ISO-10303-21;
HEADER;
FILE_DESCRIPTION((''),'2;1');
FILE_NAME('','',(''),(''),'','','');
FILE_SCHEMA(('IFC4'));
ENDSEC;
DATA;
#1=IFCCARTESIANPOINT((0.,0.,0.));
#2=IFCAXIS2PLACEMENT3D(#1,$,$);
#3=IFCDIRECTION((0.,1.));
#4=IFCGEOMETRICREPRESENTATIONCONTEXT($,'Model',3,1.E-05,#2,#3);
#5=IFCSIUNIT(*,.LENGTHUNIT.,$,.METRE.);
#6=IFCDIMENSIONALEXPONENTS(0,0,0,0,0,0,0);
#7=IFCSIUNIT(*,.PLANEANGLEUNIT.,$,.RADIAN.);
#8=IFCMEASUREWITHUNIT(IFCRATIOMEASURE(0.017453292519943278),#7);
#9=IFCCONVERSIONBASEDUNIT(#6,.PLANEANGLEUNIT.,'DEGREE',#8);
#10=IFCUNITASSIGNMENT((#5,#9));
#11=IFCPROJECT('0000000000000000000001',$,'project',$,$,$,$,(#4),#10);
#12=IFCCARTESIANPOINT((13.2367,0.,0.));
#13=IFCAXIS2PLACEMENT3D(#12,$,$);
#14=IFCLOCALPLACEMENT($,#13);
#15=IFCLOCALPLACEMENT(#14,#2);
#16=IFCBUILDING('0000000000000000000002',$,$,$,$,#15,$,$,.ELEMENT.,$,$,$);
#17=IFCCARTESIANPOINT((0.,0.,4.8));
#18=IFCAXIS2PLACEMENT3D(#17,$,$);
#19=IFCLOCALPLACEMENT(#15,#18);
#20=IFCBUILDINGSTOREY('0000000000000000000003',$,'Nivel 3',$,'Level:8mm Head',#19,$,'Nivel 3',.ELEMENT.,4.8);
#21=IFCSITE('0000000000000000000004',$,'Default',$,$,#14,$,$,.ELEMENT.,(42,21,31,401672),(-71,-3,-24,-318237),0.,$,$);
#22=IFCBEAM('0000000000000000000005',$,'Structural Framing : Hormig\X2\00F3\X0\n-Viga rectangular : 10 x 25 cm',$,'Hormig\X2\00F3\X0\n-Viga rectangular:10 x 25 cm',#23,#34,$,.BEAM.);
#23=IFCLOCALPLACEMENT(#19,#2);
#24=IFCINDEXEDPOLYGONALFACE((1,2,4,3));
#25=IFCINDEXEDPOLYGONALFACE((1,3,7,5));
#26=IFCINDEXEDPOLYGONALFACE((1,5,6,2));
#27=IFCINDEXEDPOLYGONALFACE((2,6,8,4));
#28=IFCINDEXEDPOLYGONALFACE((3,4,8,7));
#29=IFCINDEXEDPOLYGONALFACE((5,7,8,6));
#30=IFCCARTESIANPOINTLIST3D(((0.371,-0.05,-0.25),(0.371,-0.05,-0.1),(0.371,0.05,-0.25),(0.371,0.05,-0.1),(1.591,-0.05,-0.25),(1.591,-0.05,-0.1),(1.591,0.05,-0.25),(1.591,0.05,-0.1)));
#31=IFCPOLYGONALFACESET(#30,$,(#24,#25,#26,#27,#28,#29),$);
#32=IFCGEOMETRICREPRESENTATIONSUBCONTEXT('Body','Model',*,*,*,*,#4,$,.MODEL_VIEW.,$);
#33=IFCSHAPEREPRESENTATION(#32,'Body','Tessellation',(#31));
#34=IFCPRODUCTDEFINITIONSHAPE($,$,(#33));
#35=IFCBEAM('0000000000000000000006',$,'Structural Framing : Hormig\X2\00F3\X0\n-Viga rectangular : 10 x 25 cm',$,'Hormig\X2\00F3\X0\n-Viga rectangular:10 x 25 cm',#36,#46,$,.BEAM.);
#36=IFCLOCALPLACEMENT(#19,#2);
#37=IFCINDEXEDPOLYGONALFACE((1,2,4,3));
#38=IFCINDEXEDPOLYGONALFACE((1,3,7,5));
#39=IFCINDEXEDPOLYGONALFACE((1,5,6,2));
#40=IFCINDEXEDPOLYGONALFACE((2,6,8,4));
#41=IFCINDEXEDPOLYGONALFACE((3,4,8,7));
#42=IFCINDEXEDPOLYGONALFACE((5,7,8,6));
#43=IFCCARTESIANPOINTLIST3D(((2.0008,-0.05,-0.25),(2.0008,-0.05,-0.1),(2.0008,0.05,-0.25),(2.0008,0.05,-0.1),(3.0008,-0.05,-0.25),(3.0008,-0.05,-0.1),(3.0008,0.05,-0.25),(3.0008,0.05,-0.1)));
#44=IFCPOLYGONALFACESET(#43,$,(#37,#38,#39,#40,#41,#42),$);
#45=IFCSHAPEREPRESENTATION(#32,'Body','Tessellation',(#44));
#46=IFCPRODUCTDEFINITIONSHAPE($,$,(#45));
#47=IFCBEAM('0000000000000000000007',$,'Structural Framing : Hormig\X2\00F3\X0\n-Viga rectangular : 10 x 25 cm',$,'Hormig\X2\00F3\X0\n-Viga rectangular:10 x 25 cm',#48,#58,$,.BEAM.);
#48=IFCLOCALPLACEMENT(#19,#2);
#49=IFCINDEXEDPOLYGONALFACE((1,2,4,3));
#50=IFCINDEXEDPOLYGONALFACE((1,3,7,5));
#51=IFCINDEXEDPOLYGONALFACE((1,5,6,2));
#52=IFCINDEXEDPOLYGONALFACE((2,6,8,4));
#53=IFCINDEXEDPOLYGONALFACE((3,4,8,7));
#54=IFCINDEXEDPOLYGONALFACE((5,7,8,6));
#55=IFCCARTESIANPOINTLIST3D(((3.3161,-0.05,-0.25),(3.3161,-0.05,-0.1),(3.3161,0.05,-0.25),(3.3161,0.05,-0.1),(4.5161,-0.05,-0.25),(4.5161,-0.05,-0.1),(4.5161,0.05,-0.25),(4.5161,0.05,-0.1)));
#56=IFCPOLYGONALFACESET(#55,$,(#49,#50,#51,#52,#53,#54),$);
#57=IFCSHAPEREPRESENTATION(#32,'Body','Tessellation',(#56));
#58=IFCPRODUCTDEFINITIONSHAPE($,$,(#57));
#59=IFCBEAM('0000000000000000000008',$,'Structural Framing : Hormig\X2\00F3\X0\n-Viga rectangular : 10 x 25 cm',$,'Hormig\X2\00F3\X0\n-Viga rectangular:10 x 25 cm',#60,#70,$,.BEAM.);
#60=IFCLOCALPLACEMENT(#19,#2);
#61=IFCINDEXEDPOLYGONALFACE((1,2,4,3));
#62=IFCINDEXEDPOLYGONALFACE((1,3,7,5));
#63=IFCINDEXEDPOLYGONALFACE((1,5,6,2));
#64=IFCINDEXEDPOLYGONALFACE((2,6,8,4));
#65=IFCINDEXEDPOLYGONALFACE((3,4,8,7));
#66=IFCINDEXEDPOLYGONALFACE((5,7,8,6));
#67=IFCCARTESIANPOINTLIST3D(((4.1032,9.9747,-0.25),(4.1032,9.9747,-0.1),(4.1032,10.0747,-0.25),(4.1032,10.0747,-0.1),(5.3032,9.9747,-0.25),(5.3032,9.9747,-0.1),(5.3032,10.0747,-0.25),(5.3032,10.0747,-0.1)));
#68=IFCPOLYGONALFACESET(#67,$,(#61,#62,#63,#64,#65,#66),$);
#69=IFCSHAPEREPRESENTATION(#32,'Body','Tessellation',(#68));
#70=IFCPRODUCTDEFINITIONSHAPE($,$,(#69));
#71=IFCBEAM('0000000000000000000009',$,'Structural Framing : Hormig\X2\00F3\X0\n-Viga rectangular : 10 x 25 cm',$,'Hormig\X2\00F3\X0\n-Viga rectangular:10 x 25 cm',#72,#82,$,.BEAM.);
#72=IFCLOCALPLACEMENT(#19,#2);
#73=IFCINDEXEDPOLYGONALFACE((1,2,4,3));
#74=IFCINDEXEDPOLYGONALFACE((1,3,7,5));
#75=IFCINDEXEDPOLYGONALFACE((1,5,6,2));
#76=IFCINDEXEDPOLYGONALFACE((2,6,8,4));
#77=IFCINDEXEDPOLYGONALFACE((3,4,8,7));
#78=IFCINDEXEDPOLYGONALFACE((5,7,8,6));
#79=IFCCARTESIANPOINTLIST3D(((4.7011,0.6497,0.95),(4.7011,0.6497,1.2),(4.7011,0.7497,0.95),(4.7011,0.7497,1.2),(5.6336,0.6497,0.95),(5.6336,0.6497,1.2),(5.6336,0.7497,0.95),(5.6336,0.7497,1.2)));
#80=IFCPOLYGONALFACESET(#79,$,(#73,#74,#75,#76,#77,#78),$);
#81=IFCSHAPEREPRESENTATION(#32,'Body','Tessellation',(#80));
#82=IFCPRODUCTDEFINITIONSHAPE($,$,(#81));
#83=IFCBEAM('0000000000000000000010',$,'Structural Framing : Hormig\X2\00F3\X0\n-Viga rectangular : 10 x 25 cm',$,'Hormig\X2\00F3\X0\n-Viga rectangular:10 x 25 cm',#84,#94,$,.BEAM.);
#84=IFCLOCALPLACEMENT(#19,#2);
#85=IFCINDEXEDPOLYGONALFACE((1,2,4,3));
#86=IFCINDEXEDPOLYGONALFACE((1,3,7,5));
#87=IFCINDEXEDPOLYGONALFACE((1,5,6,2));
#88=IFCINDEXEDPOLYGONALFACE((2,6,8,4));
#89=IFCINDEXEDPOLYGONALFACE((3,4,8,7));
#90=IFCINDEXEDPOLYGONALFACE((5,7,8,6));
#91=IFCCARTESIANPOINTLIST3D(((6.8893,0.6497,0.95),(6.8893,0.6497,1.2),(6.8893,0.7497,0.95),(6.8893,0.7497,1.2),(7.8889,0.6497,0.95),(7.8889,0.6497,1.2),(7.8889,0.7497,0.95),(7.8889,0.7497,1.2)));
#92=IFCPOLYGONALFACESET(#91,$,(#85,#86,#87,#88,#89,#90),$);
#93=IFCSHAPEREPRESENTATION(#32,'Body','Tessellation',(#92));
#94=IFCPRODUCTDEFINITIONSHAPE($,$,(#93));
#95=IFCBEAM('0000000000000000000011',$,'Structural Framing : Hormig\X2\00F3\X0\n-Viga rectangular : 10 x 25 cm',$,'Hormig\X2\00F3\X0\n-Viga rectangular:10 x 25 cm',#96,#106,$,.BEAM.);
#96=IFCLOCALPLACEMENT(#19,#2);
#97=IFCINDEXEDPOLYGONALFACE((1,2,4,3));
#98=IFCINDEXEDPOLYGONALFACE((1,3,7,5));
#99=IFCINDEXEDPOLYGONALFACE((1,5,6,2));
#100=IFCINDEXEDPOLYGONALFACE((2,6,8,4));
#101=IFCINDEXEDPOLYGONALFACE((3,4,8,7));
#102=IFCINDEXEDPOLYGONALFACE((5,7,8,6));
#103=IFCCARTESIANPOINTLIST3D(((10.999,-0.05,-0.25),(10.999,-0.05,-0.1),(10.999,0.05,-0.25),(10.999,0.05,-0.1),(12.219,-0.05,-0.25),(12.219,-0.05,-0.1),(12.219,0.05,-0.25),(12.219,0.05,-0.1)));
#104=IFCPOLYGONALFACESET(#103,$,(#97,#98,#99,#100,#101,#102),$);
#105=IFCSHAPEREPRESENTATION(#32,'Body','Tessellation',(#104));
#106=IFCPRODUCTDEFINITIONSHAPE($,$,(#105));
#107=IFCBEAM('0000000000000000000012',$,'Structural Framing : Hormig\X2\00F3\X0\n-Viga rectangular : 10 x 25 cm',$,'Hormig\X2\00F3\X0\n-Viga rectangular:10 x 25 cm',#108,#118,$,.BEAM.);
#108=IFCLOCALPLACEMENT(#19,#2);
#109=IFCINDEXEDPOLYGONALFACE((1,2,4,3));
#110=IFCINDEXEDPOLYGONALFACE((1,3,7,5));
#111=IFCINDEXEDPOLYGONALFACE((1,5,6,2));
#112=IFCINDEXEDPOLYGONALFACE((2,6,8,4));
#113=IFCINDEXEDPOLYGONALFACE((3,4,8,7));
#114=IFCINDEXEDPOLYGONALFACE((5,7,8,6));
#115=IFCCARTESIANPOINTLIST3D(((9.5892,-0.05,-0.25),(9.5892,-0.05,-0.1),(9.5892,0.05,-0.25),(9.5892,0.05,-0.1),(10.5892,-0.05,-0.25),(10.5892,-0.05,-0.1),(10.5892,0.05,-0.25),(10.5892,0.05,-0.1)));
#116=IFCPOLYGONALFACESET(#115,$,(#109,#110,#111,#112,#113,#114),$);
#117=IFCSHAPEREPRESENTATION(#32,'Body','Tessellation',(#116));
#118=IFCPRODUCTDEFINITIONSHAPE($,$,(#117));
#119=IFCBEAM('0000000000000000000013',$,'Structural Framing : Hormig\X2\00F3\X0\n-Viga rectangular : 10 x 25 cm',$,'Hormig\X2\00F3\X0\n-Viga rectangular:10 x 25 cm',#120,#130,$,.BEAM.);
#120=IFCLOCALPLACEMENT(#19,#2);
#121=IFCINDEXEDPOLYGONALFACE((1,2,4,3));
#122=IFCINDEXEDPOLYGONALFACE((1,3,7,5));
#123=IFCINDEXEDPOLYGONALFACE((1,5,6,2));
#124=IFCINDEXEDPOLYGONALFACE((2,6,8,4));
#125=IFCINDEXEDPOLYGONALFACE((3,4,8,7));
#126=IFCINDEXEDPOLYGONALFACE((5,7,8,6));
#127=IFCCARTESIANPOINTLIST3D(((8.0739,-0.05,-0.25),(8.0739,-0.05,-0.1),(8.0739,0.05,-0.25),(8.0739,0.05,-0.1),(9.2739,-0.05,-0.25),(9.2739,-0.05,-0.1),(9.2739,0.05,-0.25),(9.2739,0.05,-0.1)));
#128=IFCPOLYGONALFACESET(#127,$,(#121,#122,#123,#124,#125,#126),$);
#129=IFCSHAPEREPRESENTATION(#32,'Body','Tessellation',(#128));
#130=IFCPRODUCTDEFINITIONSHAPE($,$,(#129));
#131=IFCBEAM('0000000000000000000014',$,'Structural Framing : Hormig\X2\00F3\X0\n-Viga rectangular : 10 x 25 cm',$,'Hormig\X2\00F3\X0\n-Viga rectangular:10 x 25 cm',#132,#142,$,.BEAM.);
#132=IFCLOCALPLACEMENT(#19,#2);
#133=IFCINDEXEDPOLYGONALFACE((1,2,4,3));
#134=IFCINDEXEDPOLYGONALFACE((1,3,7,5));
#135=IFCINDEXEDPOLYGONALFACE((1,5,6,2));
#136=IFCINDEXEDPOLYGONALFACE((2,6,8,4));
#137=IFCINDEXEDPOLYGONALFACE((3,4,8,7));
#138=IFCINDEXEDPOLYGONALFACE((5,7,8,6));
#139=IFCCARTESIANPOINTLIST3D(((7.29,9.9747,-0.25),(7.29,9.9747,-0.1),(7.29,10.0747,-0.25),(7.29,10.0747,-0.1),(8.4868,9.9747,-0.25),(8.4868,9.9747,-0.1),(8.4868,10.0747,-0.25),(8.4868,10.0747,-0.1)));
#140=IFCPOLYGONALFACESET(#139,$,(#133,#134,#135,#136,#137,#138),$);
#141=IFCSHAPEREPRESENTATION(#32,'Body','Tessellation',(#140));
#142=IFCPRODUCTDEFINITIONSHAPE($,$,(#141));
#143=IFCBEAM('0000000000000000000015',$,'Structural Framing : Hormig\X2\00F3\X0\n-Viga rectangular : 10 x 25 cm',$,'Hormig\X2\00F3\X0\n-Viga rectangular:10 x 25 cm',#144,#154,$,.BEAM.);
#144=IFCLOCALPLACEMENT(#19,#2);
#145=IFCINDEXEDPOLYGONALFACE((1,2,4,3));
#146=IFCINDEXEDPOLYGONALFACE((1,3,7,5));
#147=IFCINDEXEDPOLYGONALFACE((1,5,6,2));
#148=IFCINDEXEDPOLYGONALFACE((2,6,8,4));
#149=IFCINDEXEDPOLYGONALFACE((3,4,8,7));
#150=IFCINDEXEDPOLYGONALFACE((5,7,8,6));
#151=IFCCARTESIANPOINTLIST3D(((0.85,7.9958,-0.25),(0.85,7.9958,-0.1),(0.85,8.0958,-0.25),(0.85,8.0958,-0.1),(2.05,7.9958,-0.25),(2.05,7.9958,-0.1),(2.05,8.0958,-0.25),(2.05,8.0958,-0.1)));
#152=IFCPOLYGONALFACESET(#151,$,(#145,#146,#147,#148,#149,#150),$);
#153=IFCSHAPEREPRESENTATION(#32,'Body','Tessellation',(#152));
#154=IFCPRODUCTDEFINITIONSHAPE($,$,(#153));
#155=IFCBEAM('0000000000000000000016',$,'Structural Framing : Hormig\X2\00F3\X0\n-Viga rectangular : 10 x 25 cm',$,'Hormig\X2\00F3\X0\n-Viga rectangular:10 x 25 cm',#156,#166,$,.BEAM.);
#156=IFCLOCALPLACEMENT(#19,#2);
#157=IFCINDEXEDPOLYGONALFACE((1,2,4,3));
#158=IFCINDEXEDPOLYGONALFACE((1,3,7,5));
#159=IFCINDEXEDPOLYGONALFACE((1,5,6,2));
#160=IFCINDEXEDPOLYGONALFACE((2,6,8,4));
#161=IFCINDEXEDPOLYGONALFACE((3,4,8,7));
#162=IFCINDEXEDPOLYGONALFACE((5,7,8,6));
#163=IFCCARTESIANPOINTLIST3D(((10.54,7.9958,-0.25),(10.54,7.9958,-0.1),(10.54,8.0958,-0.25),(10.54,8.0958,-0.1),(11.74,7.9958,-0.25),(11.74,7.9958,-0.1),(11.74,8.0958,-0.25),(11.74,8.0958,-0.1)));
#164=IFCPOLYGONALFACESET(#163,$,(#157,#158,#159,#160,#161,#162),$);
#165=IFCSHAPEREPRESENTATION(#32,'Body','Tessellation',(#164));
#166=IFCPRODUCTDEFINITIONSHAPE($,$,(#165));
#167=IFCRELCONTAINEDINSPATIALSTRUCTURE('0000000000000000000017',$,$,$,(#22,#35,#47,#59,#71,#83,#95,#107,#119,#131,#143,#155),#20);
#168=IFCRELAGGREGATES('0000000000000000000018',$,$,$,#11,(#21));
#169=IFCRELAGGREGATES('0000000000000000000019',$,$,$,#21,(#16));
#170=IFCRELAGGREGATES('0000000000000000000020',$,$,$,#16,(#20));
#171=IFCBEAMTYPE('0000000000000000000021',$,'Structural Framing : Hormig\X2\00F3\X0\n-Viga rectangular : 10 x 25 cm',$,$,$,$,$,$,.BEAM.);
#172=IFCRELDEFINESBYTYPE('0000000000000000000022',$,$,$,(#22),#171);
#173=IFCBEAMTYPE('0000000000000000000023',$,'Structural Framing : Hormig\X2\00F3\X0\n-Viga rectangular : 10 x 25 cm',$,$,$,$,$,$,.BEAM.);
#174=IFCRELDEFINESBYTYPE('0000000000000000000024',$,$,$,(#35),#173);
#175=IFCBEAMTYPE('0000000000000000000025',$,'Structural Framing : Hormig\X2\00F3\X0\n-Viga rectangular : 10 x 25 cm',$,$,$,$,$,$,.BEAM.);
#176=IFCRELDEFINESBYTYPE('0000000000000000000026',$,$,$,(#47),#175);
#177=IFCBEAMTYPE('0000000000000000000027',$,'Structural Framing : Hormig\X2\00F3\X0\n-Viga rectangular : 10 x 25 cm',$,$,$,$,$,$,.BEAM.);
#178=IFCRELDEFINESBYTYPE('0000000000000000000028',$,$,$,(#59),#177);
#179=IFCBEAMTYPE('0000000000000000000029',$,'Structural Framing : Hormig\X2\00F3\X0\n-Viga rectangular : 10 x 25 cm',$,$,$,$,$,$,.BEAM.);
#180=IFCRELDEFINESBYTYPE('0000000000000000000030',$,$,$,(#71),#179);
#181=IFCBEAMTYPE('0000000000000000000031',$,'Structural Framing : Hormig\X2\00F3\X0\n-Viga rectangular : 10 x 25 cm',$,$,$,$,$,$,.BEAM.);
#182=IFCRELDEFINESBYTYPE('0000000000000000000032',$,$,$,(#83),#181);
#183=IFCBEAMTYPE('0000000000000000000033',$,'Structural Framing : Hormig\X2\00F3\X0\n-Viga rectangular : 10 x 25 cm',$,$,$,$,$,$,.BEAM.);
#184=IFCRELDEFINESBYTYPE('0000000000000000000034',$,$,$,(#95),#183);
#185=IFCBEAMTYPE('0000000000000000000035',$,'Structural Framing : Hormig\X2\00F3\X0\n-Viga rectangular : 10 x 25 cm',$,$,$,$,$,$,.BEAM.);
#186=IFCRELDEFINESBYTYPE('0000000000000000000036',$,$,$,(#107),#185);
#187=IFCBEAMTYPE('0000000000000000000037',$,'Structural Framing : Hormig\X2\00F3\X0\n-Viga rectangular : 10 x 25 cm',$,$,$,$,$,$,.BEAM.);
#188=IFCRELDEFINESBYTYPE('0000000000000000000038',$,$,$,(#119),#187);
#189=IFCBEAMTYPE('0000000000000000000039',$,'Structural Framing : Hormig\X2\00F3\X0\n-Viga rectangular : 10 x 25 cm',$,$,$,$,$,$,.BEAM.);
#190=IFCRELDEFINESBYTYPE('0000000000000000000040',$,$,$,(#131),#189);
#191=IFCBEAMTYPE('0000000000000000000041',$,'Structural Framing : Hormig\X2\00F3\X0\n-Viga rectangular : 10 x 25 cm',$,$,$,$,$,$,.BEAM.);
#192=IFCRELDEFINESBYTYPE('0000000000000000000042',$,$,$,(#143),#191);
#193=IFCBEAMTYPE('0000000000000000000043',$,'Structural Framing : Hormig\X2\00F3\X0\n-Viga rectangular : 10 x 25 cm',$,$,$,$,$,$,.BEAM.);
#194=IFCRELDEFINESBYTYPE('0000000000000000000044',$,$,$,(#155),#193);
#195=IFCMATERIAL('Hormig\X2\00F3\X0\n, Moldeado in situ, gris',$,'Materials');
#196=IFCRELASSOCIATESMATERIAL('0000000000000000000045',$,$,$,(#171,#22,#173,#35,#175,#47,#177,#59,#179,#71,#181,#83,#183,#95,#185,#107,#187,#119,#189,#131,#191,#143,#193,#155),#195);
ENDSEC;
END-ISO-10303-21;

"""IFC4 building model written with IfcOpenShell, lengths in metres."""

from ifc_helpers import new_model, entity, si_unit, converted_unit, direction, frame, origin, place, context, subcontext, project, spatial, indexed_curve, outline, extrude, source, transform, mapped, material, type_object, type_shapes, element, save


model = new_model("IFC4")

# Units and contexts
model_context = context("Model", 3, precision=1e-05, world=origin(), true_north=direction((0.0, 1.0)))
body_context = subcontext(model_context, "Body", "Model", "MODEL_VIEW")
ifc_project = project(units=[si_unit("LENGTHUNIT", "METRE"), converted_unit("PLANEANGLEUNIT", "DEGREE", entity("IfcRatioMeasure", 0.017453292519943278), si_unit("PLANEANGLEUNIT", "RADIAN"), dimensions=[0, 0, 0, 0, 0, 0, 0])], contexts=[model_context])

# Site, building, storey
site_placement = place(None, frame((13.2367, 0.0, 0.0)))
site = spatial("IfcSite", under=ifc_project, at=site_placement, Name="Default", CompositionType="ELEMENT", RefLatitude=(42, 21, 31, 401672), RefLongitude=(-71, -3, -24, -318237), RefElevation=0.0)
building_placement = place(site_placement, origin())
building = spatial("IfcBuilding", under=site, at=building_placement, CompositionType="ELEMENT")
storey_placement = place(building_placement, frame((0.0, 0.0, 4.8)))
storey = spatial("IfcBuildingStorey", under=building, at=storey_placement, Name="Nivel 3", ObjectType="Level:8mm Head", LongName="Nivel 3", CompositionType="ELEMENT", Elevation=4.8)

# Beams
ifc_material_1 = material(Name="Hormigón, Moldeado in situ, gris", Category="Materials")
beam_type_1 = type_object("IfcBeamType", Name="Structural Framing : Hormigón-Viga rectangular : 10 x 25 cm", PredefinedType="BEAM", material=ifc_material_1)
shared_shape_1 = source(origin(), body_context, "Body", "SweptSolid", [
    extrude(outline(indexed_curve([(-0.075, -0.05), (0.075, -0.05), (0.075, 0.05), (-0.075, 0.05), (-0.075, -0.05)], self_intersect=False)), frame((0.371, 0.0, 4.625), z_axis=(1.0, 0.0, 0.0), x_axis=(0.0, 0.0, -1.0)), (0.0, 0.0, 1.0), 1.22),
])
type_shapes(beam_type_1, [shared_shape_1])
beam_1_placement = place(storey_placement, frame((0.0, 0.0, -4.8)))
element("IfcBeam", 1, at=beam_1_placement, inside=storey, type_object=beam_type_1, material=ifc_material_1, Name="Structural Framing : Hormigón-Viga rectangular : 10 x 25 cm", ObjectType="Hormigón-Viga rectangular:10 x 25 cm", PredefinedType="BEAM", context=body_context, shape_type="MappedRepresentation", body=[
    mapped(shared_shape_1, transform((0.0, 0.0, 0.0), scale=1.0)),
])
beam_type_2 = type_object("IfcBeamType", Name="Structural Framing : Hormigón-Viga rectangular : 10 x 25 cm", PredefinedType="BEAM", material=ifc_material_1)
shared_shape_2 = source(origin(), body_context, "Body", "SweptSolid", [
    extrude(outline(indexed_curve([(-0.075, -0.05), (0.075, -0.05), (0.075, 0.05), (-0.075, 0.05), (-0.075, -0.05)], self_intersect=False)), frame((2.0008, 0.0, 4.625), z_axis=(1.0, 0.0, 0.0), x_axis=(0.0, 0.0, -1.0)), (0.0, 0.0, 1.0), 1.0),
])
type_shapes(beam_type_2, [shared_shape_2])
beam_2_placement = place(storey_placement, frame((0.0, 0.0, -4.8)))
element("IfcBeam", 2, at=beam_2_placement, inside=storey, type_object=beam_type_2, material=ifc_material_1, Name="Structural Framing : Hormigón-Viga rectangular : 10 x 25 cm", ObjectType="Hormigón-Viga rectangular:10 x 25 cm", PredefinedType="BEAM", context=body_context, shape_type="MappedRepresentation", body=[
    mapped(shared_shape_2, transform((0.0, 0.0, 0.0), scale=1.0)),
])
beam_type_3 = type_object("IfcBeamType", Name="Structural Framing : Hormigón-Viga rectangular : 10 x 25 cm", PredefinedType="BEAM", material=ifc_material_1)
shared_shape_3 = source(origin(), body_context, "Body", "SweptSolid", [
    extrude(outline(indexed_curve([(-0.075, -0.05), (0.075, -0.05), (0.075, 0.05), (-0.075, 0.05), (-0.075, -0.05)], self_intersect=False)), frame((3.3161, 0.0, 4.625), z_axis=(1.0, 0.0, 0.0), x_axis=(0.0, 0.0, -1.0)), (0.0, 0.0, 1.0), 1.2),
])
type_shapes(beam_type_3, [shared_shape_3])
beam_3_placement = place(storey_placement, frame((0.0, 0.0, -4.8)))
element("IfcBeam", 3, at=beam_3_placement, inside=storey, type_object=beam_type_3, material=ifc_material_1, Name="Structural Framing : Hormigón-Viga rectangular : 10 x 25 cm", ObjectType="Hormigón-Viga rectangular:10 x 25 cm", PredefinedType="BEAM", context=body_context, shape_type="MappedRepresentation", body=[
    mapped(shared_shape_3, transform((0.0, 0.0, 0.0), scale=1.0)),
])
beam_type_4 = type_object("IfcBeamType", Name="Structural Framing : Hormigón-Viga rectangular : 10 x 25 cm", PredefinedType="BEAM", material=ifc_material_1)
shared_shape_4 = source(origin(), body_context, "Body", "SweptSolid", [
    extrude(outline(indexed_curve([(-0.075, -0.05), (0.075, -0.05), (0.075, 0.05), (-0.075, 0.05), (-0.075, -0.05)], self_intersect=False)), frame((5.3032, 10.0247, 4.625), z_axis=(-1.0, 0.0, 0.0), x_axis=(0.0, 0.0, -1.0)), (0.0, 0.0, 1.0), 1.2),
])
type_shapes(beam_type_4, [shared_shape_4])
beam_4_placement = place(storey_placement, frame((0.0, 0.0, -4.8)))
element("IfcBeam", 4, at=beam_4_placement, inside=storey, type_object=beam_type_4, material=ifc_material_1, Name="Structural Framing : Hormigón-Viga rectangular : 10 x 25 cm", ObjectType="Hormigón-Viga rectangular:10 x 25 cm", PredefinedType="BEAM", context=body_context, shape_type="MappedRepresentation", body=[
    mapped(shared_shape_4, transform((0.0, 0.0, 0.0), scale=1.0)),
])
beam_type_5 = type_object("IfcBeamType", Name="Structural Framing : Hormigón-Viga rectangular : 10 x 25 cm", PredefinedType="BEAM", material=ifc_material_1)
shared_shape_5 = source(origin(), body_context, "Body", "SweptSolid", [
    extrude(outline(indexed_curve([(-0.125, -0.05), (0.125, -0.05), (0.125, 0.05), (-0.125, 0.05), (-0.125, -0.05)], self_intersect=False)), frame((5.6336, 0.6997, 5.875), z_axis=(-1.0, 0.0, 0.0), x_axis=(0.0, 0.0, -1.0)), (0.0, 0.0, 1.0), 0.9325),
])
type_shapes(beam_type_5, [shared_shape_5])
beam_5_placement = place(storey_placement, frame((0.0, 0.0, -4.8)))
element("IfcBeam", 5, at=beam_5_placement, inside=storey, type_object=beam_type_5, material=ifc_material_1, Name="Structural Framing : Hormigón-Viga rectangular : 10 x 25 cm", ObjectType="Hormigón-Viga rectangular:10 x 25 cm", PredefinedType="BEAM", context=body_context, shape_type="MappedRepresentation", body=[
    mapped(shared_shape_5, transform((0.0, 0.0, 0.0), scale=1.0)),
])
beam_type_6 = type_object("IfcBeamType", Name="Structural Framing : Hormigón-Viga rectangular : 10 x 25 cm", PredefinedType="BEAM", material=ifc_material_1)
shared_shape_6 = source(origin(), body_context, "Body", "SweptSolid", [
    extrude(outline(indexed_curve([(-0.125, -0.05), (0.125, -0.05), (0.125, 0.05), (-0.125, 0.05), (-0.125, -0.05)], self_intersect=False)), frame((7.8889, 0.6997, 5.875), z_axis=(-1.0, 0.0, 0.0), x_axis=(0.0, 0.0, -1.0)), (0.0, 0.0, 1.0), 0.9996),
])
type_shapes(beam_type_6, [shared_shape_6])
beam_6_placement = place(storey_placement, frame((0.0, 0.0, -4.8)))
element("IfcBeam", 6, at=beam_6_placement, inside=storey, type_object=beam_type_6, material=ifc_material_1, Name="Structural Framing : Hormigón-Viga rectangular : 10 x 25 cm", ObjectType="Hormigón-Viga rectangular:10 x 25 cm", PredefinedType="BEAM", context=body_context, shape_type="MappedRepresentation", body=[
    mapped(shared_shape_6, transform((0.0, 0.0, 0.0), scale=1.0)),
])
beam_type_7 = type_object("IfcBeamType", Name="Structural Framing : Hormigón-Viga rectangular : 10 x 25 cm", PredefinedType="BEAM", material=ifc_material_1)
shared_shape_7 = source(origin(), body_context, "Body", "SweptSolid", [
    extrude(outline(indexed_curve([(-0.075, -0.05), (0.075, -0.05), (0.075, 0.05), (-0.075, 0.05), (-0.075, -0.05)], self_intersect=False)), frame((12.219, 0.0, 4.625), z_axis=(-1.0, 0.0, 0.0), x_axis=(0.0, 0.0, -1.0)), (0.0, 0.0, 1.0), 1.22),
])
type_shapes(beam_type_7, [shared_shape_7])
beam_7_placement = place(storey_placement, frame((0.0, 0.0, -4.8)))
element("IfcBeam", 7, at=beam_7_placement, inside=storey, type_object=beam_type_7, material=ifc_material_1, Name="Structural Framing : Hormigón-Viga rectangular : 10 x 25 cm", ObjectType="Hormigón-Viga rectangular:10 x 25 cm", PredefinedType="BEAM", context=body_context, shape_type="MappedRepresentation", body=[
    mapped(shared_shape_7, transform((0.0, 0.0, 0.0), scale=1.0)),
])
beam_type_8 = type_object("IfcBeamType", Name="Structural Framing : Hormigón-Viga rectangular : 10 x 25 cm", PredefinedType="BEAM", material=ifc_material_1)
shared_shape_8 = source(origin(), body_context, "Body", "SweptSolid", [
    extrude(outline(indexed_curve([(-0.075, -0.05), (0.075, -0.05), (0.075, 0.05), (-0.075, 0.05), (-0.075, -0.05)], self_intersect=False)), frame((10.5892, 0.0, 4.625), z_axis=(-1.0, 0.0, 0.0), x_axis=(0.0, 0.0, -1.0)), (0.0, 0.0, 1.0), 1.0),
])
type_shapes(beam_type_8, [shared_shape_8])
beam_8_placement = place(storey_placement, frame((0.0, 0.0, -4.8)))
element("IfcBeam", 8, at=beam_8_placement, inside=storey, type_object=beam_type_8, material=ifc_material_1, Name="Structural Framing : Hormigón-Viga rectangular : 10 x 25 cm", ObjectType="Hormigón-Viga rectangular:10 x 25 cm", PredefinedType="BEAM", context=body_context, shape_type="MappedRepresentation", body=[
    mapped(shared_shape_8, transform((0.0, 0.0, 0.0), scale=1.0)),
])
beam_type_9 = type_object("IfcBeamType", Name="Structural Framing : Hormigón-Viga rectangular : 10 x 25 cm", PredefinedType="BEAM", material=ifc_material_1)
shared_shape_9 = source(origin(), body_context, "Body", "SweptSolid", [
    extrude(outline(indexed_curve([(-0.075, -0.05), (0.075, -0.05), (0.075, 0.05), (-0.075, 0.05), (-0.075, -0.05)], self_intersect=False)), frame((9.2739, 0.0, 4.625), z_axis=(-1.0, 0.0, 0.0), x_axis=(0.0, 0.0, -1.0)), (0.0, 0.0, 1.0), 1.2),
])
type_shapes(beam_type_9, [shared_shape_9])
beam_9_placement = place(storey_placement, frame((0.0, 0.0, -4.8)))
element("IfcBeam", 9, at=beam_9_placement, inside=storey, type_object=beam_type_9, material=ifc_material_1, Name="Structural Framing : Hormigón-Viga rectangular : 10 x 25 cm", ObjectType="Hormigón-Viga rectangular:10 x 25 cm", PredefinedType="BEAM", context=body_context, shape_type="MappedRepresentation", body=[
    mapped(shared_shape_9, transform((0.0, 0.0, 0.0), scale=1.0)),
])
beam_type_10 = type_object("IfcBeamType", Name="Structural Framing : Hormigón-Viga rectangular : 10 x 25 cm", PredefinedType="BEAM", material=ifc_material_1)
shared_shape_10 = source(origin(), body_context, "Body", "SweptSolid", [
    extrude(outline(indexed_curve([(-0.075, -0.05), (0.075, -0.05), (0.075, 0.05), (-0.075, 0.05), (-0.075, -0.05)], self_intersect=False)), frame((7.29, 10.0247, 4.625), z_axis=(1.0, 0.0, 0.0), x_axis=(0.0, 0.0, -1.0)), (0.0, 0.0, 1.0), 1.1968),
])
type_shapes(beam_type_10, [shared_shape_10])
beam_10_placement = place(storey_placement, frame((0.0, 0.0, -4.8)))
element("IfcBeam", 10, at=beam_10_placement, inside=storey, type_object=beam_type_10, material=ifc_material_1, Name="Structural Framing : Hormigón-Viga rectangular : 10 x 25 cm", ObjectType="Hormigón-Viga rectangular:10 x 25 cm", PredefinedType="BEAM", context=body_context, shape_type="MappedRepresentation", body=[
    mapped(shared_shape_10, transform((0.0, 0.0, 0.0), scale=1.0)),
])
beam_type_11 = type_object("IfcBeamType", Name="Structural Framing : Hormigón-Viga rectangular : 10 x 25 cm", PredefinedType="BEAM", material=ifc_material_1)
shared_shape_11 = source(origin(), body_context, "Body", "SweptSolid", [
    extrude(outline(indexed_curve([(-0.075, -0.05), (0.075, -0.05), (0.075, 0.05), (-0.075, 0.05), (-0.075, -0.05)], self_intersect=False)), frame((2.05, 8.0458, 4.625), z_axis=(-1.0, 0.0, 0.0), x_axis=(0.0, 0.0, -1.0)), (0.0, 0.0, 1.0), 1.2),
])
type_shapes(beam_type_11, [shared_shape_11])
beam_11_placement = place(storey_placement, frame((0.0, 0.0, -4.8)))
element("IfcBeam", 11, at=beam_11_placement, inside=storey, type_object=beam_type_11, material=ifc_material_1, Name="Structural Framing : Hormigón-Viga rectangular : 10 x 25 cm", ObjectType="Hormigón-Viga rectangular:10 x 25 cm", PredefinedType="BEAM", context=body_context, shape_type="MappedRepresentation", body=[
    mapped(shared_shape_11, transform((0.0, 0.0, 0.0), scale=1.0)),
])
beam_type_12 = type_object("IfcBeamType", Name="Structural Framing : Hormigón-Viga rectangular : 10 x 25 cm", PredefinedType="BEAM", material=ifc_material_1)
shared_shape_12 = source(origin(), body_context, "Body", "SweptSolid", [
    extrude(outline(indexed_curve([(-0.075, -0.05), (0.075, -0.05), (0.075, 0.05), (-0.075, 0.05), (-0.075, -0.05)], self_intersect=False)), frame((10.54, 8.0458, 4.625), z_axis=(1.0, 0.0, 0.0), x_axis=(0.0, 0.0, -1.0)), (0.0, 0.0, 1.0), 1.2),
])
type_shapes(beam_type_12, [shared_shape_12])
beam_12_placement = place(storey_placement, frame((0.0, 0.0, -4.8)))
element("IfcBeam", 12, at=beam_12_placement, inside=storey, type_object=beam_type_12, material=ifc_material_1, Name="Structural Framing : Hormigón-Viga rectangular : 10 x 25 cm", ObjectType="Hormigón-Viga rectangular:10 x 25 cm", PredefinedType="BEAM", context=body_context, shape_type="MappedRepresentation", body=[
    mapped(shared_shape_12, transform((0.0, 0.0, 0.0), scale=1.0)),
])

save(model, "model.ifc")
